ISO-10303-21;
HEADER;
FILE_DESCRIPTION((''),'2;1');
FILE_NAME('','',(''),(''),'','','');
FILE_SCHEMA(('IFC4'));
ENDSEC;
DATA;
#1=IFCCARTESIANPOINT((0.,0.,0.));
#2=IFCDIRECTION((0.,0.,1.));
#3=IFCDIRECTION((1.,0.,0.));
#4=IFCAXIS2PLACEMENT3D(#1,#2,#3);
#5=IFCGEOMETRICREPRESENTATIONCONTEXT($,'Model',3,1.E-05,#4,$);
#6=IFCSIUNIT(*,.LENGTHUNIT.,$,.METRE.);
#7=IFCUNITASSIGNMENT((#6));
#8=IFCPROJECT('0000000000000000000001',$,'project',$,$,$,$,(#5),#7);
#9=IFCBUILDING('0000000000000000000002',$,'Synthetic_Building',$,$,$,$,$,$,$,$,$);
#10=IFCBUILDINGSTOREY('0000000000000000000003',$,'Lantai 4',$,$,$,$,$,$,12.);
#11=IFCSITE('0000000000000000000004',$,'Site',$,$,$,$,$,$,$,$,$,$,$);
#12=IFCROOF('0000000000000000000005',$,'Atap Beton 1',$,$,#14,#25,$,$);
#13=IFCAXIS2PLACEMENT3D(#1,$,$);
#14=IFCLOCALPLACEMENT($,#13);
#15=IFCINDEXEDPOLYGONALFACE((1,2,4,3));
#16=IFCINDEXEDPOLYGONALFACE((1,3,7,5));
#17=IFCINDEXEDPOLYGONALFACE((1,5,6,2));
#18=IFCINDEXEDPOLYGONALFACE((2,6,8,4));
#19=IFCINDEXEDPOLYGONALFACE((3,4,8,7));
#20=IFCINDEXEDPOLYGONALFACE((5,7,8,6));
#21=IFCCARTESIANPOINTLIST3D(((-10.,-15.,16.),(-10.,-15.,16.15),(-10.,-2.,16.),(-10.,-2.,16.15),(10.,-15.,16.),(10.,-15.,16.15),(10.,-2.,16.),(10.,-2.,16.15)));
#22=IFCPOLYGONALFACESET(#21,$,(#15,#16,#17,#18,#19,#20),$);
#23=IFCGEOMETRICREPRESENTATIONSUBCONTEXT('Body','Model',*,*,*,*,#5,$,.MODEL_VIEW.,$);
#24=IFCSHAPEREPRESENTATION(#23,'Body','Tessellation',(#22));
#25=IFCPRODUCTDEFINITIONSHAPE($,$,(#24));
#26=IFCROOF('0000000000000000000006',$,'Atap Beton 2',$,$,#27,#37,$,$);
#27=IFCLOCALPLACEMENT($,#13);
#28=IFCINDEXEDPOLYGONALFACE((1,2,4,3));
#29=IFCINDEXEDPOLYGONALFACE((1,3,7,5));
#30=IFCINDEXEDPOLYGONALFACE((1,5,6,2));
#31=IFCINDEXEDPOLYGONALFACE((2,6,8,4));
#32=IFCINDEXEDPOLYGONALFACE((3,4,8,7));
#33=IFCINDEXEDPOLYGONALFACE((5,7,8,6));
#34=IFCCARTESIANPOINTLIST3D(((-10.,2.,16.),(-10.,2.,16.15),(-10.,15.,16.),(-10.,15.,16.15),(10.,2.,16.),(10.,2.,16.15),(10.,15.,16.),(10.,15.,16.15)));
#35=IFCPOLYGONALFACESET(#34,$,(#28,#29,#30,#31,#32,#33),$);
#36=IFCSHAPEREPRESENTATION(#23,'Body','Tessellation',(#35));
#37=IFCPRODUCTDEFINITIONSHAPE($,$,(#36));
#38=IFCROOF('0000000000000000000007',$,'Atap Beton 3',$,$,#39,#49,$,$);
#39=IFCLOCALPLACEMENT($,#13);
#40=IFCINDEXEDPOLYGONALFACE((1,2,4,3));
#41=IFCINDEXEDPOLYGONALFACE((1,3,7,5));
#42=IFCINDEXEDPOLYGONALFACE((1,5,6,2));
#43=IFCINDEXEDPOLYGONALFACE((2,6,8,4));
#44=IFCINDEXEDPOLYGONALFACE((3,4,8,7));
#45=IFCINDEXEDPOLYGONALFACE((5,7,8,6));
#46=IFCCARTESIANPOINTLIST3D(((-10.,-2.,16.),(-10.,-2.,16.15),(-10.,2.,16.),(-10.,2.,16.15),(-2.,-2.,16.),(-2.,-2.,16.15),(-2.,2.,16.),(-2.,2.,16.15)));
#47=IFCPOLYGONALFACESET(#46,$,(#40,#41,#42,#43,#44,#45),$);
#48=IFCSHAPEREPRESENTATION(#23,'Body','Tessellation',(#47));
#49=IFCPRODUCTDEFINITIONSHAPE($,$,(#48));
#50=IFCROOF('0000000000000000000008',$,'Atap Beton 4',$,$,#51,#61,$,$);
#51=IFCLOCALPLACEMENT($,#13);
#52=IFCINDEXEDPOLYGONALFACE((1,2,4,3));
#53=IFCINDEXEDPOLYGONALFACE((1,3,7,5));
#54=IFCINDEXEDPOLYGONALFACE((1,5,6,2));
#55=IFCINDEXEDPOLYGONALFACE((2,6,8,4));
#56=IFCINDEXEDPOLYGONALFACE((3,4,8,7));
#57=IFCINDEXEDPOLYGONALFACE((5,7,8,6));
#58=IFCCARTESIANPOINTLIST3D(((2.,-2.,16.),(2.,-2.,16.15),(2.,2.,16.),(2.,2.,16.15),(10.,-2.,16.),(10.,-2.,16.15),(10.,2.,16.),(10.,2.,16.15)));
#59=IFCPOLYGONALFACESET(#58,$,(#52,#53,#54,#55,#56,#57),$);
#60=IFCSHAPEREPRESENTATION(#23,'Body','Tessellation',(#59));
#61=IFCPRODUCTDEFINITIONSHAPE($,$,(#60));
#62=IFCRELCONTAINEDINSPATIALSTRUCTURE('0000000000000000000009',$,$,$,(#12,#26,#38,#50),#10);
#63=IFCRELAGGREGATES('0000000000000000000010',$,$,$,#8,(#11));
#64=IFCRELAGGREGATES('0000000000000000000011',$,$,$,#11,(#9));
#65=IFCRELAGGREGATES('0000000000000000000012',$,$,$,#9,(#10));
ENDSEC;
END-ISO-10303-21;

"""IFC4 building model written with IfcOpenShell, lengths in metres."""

from ifc_helpers import new_model, si_unit, frame, origin_with_axes, place, context, subcontext, project, spatial, polyline, outline, extrude, element, save


model = new_model("IFC4")

# Units and contexts
model_context = context("Model", 3, precision=1e-05, world=origin_with_axes())
body_context = subcontext(model_context, "Body", "Model", "MODEL_VIEW")
ifc_project = project(units=[si_unit("LENGTHUNIT", "METRE")], contexts=[model_context])

# Site, building, storey
site = spatial("IfcSite", under=ifc_project, Name="Site")
building = spatial("IfcBuilding", under=site, Name="Synthetic_Building")
storey = spatial("IfcBuildingStorey", under=building, Name="Lantai 4", Elevation=12.0)

# Roofs
roof_1_placement = place(None, origin_with_axes())
element("IfcRoof", 1, at=roof_1_placement, inside=storey, Name="Atap Beton 1", context=body_context, shape_type="SweptSolid", body=[
    extrude(outline(polyline([(-10.0, -15.0), (10.0, -15.0), (10.0, -2.0), (-10.0, -2.0), (-10.0, -15.0)])), frame((0.0, 0.0, 16.0), z_axis=(0.0, 0.0, 1.0), x_axis=(1.0, 0.0, 0.0)), (0.0, 0.0, 1.0), 0.15),
])
roof_2_placement = place(None, origin_with_axes())
element("IfcRoof", 2, at=roof_2_placement, inside=storey, Name="Atap Beton 2", context=body_context, shape_type="SweptSolid", body=[
    extrude(outline(polyline([(-10.0, 2.0), (10.0, 2.0), (10.0, 15.0), (-10.0, 15.0), (-10.0, 2.0)])), frame((0.0, 0.0, 16.0), z_axis=(0.0, 0.0, 1.0), x_axis=(1.0, 0.0, 0.0)), (0.0, 0.0, 1.0), 0.15),
])
roof_3_placement = place(None, origin_with_axes())
element("IfcRoof", 3, at=roof_3_placement, inside=storey, Name="Atap Beton 3", context=body_context, shape_type="SweptSolid", body=[
    extrude(outline(polyline([(-10.0, -2.0), (-2.0, -2.0), (-2.0, 2.0), (-10.0, 2.0), (-10.0, -2.0)])), frame((0.0, 0.0, 16.0), z_axis=(0.0, 0.0, 1.0), x_axis=(1.0, 0.0, 0.0)), (0.0, 0.0, 1.0), 0.15),
])
roof_4_placement = place(None, origin_with_axes())
element("IfcRoof", 4, at=roof_4_placement, inside=storey, Name="Atap Beton 4", context=body_context, shape_type="SweptSolid", body=[
    extrude(outline(polyline([(2.0, -2.0), (10.0, -2.0), (10.0, 2.0), (2.0, 2.0), (2.0, -2.0)])), frame((0.0, 0.0, 16.0), z_axis=(0.0, 0.0, 1.0), x_axis=(1.0, 0.0, 0.0)), (0.0, 0.0, 1.0), 0.15),
])

save(model, "model.ifc")
